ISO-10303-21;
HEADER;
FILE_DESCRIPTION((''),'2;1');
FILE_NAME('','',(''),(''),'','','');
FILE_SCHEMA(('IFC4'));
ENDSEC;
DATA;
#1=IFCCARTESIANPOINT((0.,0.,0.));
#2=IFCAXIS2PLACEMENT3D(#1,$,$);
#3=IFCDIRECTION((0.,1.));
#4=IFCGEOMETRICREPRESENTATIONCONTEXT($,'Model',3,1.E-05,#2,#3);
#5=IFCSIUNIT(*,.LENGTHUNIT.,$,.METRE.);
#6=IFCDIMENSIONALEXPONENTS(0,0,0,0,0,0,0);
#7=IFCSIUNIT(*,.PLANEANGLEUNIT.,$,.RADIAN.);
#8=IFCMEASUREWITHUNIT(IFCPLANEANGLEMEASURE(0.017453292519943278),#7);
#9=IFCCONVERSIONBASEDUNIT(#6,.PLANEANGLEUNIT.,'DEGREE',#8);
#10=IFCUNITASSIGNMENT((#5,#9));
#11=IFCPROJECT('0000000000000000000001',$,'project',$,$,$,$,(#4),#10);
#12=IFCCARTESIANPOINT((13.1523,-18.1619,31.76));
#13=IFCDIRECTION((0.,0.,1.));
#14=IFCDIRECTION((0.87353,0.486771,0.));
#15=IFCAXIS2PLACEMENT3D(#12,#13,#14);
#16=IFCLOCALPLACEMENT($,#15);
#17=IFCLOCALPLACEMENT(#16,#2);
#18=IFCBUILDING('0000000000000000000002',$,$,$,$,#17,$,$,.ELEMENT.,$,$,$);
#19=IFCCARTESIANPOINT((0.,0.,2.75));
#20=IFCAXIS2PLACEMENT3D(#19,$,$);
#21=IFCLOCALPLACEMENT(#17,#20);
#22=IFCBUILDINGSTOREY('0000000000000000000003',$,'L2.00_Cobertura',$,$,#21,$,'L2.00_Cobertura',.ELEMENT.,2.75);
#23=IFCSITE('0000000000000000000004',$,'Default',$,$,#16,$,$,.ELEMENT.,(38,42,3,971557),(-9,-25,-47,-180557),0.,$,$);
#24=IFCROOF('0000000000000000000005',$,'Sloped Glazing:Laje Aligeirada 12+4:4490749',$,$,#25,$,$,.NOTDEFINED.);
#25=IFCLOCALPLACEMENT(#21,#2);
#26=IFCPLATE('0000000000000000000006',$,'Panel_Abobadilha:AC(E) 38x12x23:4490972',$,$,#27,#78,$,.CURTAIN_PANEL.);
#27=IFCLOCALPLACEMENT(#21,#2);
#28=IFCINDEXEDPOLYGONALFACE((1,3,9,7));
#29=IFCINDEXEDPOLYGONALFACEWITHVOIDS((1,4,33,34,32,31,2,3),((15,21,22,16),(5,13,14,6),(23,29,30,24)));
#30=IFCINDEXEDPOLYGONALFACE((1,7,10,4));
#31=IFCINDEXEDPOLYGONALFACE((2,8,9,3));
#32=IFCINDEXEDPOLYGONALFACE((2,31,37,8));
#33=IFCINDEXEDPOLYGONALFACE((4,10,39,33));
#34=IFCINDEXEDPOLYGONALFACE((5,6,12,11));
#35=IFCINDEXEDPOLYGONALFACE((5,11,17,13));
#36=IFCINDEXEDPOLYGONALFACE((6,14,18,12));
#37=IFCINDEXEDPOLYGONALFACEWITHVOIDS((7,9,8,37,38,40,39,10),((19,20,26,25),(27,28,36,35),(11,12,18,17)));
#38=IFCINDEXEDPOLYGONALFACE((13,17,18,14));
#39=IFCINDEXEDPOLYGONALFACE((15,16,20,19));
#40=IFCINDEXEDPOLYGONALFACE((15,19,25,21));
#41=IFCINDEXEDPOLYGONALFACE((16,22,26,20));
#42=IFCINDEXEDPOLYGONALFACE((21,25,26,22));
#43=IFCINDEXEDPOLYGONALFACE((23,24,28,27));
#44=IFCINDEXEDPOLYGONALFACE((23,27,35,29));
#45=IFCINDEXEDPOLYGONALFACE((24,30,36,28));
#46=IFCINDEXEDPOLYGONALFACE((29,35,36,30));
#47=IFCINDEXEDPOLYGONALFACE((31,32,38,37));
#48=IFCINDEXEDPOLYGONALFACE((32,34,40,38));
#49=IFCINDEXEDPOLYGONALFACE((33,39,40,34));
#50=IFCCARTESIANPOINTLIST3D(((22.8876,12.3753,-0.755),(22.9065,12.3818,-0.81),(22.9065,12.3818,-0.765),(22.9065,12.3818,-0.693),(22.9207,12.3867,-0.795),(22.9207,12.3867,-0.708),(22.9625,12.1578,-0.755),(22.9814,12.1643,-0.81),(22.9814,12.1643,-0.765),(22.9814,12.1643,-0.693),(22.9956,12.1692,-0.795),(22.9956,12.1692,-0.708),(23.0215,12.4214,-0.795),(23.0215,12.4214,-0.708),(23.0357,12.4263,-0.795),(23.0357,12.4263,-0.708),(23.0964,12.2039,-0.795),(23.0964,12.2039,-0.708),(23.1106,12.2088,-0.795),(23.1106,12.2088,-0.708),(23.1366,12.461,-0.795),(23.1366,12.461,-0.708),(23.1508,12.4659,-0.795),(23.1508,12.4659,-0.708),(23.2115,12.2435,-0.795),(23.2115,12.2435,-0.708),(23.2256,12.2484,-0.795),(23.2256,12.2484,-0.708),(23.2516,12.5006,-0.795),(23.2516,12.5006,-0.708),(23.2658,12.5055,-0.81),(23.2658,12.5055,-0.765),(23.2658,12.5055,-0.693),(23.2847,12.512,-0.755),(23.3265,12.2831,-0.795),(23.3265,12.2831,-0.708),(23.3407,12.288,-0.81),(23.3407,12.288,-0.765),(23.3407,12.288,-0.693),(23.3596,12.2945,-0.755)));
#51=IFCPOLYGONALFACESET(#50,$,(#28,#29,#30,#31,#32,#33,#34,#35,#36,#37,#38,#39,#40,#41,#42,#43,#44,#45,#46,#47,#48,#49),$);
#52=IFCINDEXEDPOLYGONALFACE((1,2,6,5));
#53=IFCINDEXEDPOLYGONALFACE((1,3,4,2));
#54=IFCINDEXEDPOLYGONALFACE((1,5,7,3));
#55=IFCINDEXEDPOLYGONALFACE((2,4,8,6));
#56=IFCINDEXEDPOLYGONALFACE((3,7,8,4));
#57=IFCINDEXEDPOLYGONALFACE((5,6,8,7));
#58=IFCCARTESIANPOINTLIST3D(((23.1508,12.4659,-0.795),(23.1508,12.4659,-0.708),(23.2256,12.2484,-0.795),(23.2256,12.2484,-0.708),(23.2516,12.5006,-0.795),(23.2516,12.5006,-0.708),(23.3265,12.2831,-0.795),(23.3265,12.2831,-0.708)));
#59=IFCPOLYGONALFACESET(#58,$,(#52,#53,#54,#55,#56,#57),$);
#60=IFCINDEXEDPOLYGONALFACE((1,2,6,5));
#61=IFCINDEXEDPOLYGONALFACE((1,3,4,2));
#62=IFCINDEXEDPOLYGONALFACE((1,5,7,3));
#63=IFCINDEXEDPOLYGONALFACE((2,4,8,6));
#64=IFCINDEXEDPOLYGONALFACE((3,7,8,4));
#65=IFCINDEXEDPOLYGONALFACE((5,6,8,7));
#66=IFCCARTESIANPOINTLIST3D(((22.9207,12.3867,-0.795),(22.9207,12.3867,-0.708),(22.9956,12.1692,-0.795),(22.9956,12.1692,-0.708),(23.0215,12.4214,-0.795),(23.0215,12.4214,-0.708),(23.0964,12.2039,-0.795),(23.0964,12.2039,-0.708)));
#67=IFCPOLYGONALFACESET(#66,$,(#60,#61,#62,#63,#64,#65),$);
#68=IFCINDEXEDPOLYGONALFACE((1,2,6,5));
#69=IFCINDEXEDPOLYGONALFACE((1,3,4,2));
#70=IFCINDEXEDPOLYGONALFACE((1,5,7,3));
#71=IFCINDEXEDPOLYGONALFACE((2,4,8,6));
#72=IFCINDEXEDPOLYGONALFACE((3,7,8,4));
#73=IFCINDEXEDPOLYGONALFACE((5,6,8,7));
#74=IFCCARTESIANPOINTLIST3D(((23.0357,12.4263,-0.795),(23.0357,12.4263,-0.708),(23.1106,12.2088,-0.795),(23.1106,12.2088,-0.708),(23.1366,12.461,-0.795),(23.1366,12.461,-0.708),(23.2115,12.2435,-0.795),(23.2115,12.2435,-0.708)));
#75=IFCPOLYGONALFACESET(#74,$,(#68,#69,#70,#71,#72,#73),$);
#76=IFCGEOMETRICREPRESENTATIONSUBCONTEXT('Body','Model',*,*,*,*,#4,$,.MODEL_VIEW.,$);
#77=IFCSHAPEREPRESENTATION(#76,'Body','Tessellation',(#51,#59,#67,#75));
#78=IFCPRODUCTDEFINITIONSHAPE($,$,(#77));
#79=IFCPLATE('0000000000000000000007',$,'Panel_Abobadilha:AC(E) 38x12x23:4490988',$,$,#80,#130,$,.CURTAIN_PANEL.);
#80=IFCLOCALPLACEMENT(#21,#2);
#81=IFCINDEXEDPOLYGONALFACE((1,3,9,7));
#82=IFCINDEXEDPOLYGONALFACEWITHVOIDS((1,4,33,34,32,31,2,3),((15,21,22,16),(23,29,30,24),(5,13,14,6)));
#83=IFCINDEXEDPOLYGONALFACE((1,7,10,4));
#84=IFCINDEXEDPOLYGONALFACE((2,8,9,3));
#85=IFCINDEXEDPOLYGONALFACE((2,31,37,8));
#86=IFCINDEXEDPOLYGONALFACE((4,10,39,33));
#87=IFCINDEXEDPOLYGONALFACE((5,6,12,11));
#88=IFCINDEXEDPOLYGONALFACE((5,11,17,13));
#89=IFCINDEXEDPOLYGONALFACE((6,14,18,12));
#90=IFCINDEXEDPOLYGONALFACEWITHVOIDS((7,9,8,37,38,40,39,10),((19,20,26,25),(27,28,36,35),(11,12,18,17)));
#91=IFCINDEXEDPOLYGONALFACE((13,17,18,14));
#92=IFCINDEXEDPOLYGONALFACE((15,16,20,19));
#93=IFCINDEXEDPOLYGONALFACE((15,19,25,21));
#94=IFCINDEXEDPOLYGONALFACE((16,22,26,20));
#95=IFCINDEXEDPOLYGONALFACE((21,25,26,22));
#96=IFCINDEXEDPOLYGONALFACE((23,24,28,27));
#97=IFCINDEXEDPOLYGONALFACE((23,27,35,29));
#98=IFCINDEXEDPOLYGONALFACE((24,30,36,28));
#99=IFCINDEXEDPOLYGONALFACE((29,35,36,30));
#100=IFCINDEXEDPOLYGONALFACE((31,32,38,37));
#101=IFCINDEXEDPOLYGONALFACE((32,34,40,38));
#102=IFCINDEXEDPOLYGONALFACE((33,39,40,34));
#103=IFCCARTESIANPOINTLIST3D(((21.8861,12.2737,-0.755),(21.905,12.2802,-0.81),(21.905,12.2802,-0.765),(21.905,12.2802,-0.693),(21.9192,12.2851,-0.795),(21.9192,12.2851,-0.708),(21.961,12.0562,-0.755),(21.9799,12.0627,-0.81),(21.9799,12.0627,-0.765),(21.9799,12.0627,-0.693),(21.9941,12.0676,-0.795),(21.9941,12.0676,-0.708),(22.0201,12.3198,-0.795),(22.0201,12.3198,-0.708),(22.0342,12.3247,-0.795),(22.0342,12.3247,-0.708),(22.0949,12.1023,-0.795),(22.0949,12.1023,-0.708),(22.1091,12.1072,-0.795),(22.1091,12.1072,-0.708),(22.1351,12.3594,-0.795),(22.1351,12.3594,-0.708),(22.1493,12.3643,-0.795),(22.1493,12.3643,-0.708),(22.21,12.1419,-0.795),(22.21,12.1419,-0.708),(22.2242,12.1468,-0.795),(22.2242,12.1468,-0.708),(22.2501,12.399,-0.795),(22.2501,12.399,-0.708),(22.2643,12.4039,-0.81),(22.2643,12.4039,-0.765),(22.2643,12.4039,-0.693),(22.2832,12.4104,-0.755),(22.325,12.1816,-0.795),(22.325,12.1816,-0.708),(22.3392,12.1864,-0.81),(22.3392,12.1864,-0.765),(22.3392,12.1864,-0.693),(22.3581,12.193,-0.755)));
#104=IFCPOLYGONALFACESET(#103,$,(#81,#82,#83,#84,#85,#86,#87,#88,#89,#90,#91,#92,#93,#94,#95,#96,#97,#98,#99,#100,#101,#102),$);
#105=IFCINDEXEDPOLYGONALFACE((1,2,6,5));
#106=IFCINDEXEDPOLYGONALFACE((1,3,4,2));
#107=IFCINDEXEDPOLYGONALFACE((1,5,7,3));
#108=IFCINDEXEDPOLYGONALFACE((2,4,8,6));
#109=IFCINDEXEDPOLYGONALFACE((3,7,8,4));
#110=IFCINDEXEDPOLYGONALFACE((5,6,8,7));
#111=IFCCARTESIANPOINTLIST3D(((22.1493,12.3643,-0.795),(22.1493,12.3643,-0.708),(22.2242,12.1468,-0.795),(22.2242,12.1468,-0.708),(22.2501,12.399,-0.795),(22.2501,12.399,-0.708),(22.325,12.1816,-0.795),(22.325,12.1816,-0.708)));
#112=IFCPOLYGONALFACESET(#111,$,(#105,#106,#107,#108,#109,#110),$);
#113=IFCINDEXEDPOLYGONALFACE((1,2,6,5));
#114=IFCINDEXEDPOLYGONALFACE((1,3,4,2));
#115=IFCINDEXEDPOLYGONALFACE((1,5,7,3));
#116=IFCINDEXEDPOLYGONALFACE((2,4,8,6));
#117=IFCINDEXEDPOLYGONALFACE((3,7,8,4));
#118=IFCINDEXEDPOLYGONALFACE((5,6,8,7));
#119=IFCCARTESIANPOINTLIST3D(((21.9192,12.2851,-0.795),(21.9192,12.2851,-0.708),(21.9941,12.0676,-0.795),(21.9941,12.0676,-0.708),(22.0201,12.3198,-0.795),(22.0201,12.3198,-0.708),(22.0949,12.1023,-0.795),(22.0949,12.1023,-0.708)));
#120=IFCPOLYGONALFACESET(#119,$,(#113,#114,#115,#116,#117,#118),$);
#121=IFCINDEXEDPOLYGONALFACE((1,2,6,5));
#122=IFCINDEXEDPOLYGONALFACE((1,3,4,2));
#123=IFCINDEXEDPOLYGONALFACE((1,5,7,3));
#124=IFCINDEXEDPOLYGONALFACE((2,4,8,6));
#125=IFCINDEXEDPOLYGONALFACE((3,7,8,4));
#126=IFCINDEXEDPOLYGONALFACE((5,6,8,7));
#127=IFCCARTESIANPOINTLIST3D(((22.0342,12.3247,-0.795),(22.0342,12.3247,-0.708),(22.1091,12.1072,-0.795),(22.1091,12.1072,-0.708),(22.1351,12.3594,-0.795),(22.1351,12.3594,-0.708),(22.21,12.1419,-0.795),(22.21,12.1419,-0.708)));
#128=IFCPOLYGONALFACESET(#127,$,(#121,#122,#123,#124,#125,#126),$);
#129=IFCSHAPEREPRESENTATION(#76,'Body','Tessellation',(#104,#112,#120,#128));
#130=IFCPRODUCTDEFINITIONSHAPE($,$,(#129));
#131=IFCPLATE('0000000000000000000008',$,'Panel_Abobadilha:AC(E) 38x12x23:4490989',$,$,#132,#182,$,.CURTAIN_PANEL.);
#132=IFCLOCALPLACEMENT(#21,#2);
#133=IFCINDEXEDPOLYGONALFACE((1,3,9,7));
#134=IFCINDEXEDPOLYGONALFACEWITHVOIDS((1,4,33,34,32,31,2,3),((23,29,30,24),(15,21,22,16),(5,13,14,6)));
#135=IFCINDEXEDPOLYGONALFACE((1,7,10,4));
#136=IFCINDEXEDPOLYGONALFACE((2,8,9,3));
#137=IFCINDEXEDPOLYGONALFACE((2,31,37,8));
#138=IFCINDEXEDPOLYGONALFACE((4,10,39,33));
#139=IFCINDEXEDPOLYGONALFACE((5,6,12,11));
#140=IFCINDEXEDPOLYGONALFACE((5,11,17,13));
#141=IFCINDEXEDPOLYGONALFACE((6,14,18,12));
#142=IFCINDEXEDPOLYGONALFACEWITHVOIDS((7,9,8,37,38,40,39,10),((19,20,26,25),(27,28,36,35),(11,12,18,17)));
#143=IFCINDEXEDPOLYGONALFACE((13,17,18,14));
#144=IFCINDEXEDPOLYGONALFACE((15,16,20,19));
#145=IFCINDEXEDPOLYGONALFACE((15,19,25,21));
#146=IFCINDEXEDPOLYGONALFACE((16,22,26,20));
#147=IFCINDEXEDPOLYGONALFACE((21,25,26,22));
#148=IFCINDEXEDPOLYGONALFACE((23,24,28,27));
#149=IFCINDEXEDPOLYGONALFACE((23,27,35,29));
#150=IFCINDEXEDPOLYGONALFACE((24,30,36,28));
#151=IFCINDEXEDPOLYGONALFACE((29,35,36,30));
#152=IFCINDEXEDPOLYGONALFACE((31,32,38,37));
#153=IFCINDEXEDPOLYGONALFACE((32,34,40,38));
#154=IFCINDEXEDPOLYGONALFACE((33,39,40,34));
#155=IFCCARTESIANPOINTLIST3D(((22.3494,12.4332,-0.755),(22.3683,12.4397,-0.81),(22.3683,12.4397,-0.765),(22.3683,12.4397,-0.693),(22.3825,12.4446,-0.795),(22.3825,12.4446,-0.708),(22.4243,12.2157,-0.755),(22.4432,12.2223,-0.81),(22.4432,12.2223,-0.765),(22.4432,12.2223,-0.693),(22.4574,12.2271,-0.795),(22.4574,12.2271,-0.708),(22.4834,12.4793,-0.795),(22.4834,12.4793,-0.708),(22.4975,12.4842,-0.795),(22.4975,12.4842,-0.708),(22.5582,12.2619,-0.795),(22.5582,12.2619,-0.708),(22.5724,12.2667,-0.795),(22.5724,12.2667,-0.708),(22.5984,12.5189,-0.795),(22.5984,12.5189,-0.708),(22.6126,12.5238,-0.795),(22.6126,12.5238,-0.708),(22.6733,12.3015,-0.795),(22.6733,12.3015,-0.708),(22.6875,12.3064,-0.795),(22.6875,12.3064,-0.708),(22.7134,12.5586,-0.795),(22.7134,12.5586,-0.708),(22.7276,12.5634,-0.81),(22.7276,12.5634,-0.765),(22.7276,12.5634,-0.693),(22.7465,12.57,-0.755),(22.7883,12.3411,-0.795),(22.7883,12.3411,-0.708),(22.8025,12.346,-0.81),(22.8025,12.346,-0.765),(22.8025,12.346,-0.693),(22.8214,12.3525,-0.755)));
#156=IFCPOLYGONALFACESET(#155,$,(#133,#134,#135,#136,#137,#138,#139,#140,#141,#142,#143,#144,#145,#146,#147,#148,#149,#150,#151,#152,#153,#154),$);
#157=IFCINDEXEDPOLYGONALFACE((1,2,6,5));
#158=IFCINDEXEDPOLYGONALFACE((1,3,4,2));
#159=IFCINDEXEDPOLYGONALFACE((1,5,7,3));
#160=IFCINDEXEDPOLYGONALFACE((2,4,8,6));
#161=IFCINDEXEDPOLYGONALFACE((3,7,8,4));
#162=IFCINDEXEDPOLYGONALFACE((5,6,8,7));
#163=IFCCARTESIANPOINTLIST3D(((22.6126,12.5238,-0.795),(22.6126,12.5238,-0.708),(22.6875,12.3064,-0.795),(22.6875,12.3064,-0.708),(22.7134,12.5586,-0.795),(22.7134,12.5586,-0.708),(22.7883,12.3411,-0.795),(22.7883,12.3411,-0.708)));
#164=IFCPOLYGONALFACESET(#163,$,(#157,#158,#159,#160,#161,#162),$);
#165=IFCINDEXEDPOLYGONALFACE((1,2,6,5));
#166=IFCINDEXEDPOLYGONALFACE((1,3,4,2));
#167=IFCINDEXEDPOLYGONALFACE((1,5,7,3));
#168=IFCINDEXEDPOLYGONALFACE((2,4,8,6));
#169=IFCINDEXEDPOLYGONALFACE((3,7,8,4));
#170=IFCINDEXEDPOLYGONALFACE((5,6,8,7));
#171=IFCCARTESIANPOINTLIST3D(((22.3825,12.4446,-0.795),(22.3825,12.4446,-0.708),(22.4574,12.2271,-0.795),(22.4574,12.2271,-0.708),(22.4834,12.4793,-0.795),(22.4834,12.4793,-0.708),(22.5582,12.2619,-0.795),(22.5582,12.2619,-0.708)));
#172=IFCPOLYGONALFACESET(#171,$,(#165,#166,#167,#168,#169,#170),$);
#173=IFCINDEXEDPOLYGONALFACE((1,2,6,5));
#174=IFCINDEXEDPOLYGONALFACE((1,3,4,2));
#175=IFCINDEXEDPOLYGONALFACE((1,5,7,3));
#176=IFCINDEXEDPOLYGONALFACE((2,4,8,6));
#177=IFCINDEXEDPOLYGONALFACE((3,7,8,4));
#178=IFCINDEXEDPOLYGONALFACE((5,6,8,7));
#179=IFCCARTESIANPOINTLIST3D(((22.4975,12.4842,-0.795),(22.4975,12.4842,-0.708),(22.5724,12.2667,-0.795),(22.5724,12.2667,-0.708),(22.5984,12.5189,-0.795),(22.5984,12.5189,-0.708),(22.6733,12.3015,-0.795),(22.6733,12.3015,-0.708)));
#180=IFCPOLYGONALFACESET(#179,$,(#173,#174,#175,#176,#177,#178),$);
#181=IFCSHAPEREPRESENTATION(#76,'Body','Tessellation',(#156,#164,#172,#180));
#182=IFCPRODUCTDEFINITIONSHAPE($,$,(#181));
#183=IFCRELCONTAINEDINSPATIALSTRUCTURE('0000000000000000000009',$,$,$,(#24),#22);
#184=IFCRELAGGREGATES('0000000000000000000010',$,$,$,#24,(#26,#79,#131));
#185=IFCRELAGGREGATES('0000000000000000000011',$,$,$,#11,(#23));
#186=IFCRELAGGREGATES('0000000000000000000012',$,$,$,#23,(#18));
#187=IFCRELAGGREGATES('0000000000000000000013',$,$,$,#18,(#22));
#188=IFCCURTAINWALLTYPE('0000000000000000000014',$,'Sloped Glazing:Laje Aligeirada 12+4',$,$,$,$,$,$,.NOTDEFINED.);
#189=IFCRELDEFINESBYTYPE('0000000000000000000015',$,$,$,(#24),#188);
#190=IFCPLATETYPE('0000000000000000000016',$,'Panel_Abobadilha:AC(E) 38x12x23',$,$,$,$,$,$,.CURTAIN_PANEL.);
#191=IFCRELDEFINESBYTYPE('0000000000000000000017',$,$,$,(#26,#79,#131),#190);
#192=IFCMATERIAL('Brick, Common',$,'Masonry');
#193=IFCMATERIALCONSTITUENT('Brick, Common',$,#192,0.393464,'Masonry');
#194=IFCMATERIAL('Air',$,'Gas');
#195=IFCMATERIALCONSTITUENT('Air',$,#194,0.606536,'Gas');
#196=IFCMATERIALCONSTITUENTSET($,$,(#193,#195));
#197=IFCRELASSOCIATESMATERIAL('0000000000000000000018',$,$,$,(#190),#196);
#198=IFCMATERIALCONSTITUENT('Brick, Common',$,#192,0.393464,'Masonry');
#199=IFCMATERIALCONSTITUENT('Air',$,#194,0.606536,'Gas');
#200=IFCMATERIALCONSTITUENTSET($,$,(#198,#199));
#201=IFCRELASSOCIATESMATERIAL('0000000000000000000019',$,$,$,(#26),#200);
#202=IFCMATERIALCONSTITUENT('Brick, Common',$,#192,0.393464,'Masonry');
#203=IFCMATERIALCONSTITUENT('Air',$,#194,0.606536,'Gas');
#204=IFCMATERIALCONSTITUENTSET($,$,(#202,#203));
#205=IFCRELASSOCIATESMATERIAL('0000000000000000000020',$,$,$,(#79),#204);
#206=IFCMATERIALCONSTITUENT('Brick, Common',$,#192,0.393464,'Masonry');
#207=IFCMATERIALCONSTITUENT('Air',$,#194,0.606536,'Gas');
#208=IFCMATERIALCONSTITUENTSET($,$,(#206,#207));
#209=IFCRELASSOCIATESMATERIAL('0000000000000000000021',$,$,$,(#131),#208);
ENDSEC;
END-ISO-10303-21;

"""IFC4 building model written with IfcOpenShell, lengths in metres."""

from ifc_helpers import new_model, entity, si_unit, converted_unit, direction, frame, origin, place, context, subcontext, project, spatial, indexed_curve, outline, extrude, source, transform, mapped, material, constituent, constituent_set, type_object, type_shapes, element, aggregate, save


model = new_model("IFC4")

# Units and contexts
model_context = context("Model", 3, precision=1e-05, world=origin(), true_north=direction((0.0, 1.0)))
body_context = subcontext(model_context, "Body", "Model", "MODEL_VIEW")
ifc_project = project(units=[si_unit("LENGTHUNIT", "METRE"), converted_unit("PLANEANGLEUNIT", "DEGREE", entity("IfcPlaneAngleMeasure", 0.017453292519943278), si_unit("PLANEANGLEUNIT", "RADIAN"), dimensions=[0, 0, 0, 0, 0, 0, 0])], contexts=[model_context])

# Site, building, storey
site_placement = place(None, frame((13.1523, -18.1619, 31.76), z_axis=(0.0, 0.0, 1.0), x_axis=(0.87353, 0.486771, 0.0)))
site = spatial("IfcSite", under=ifc_project, at=site_placement, Name="Default", CompositionType="ELEMENT", RefLatitude=(38, 42, 3, 971557), RefLongitude=(-9, -25, -47, -180557), RefElevation=0.0)
building_placement = place(site_placement, origin())
building = spatial("IfcBuilding", under=site, at=building_placement, CompositionType="ELEMENT")
storey_placement = place(building_placement, frame((0.0, 0.0, 2.75)))
storey = spatial("IfcBuildingStorey", under=building, at=storey_placement, Name="L2.00_Cobertura", LongName="L2.00_Cobertura", CompositionType="ELEMENT", Elevation=2.75)

# Roof, plates
curtain_wall_type = type_object("IfcCurtainWallType", Name="Sloped Glazing:Laje Aligeirada 12+4", PredefinedType="NOTDEFINED")
roof_placement = place(storey_placement, frame((0.0, 0.0, -2.75)))
roof = element("IfcRoof", 1, at=roof_placement, inside=storey, type_object=curtain_wall_type, Name="Sloped Glazing:Laje Aligeirada 12+4:4490749", PredefinedType="NOTDEFINED")
ifc_material_1 = material(Name="Brick, Common", Category="Masonry")
ifc_material_2 = material(Name="Air", Category="Gas")
ifc_constituent_1 = constituent(ifc_material_1, Name="Brick, Common", Category="Masonry", fraction=0.393464)
ifc_constituent_2 = constituent(ifc_material_2, Name="Air", Category="Gas", fraction=0.606536)
ifc_constituent_set_1 = constituent_set(constituents=[ifc_constituent_1, ifc_constituent_2])
plate_type = type_object("IfcPlateType", Name="Panel_Abobadilha:AC(E) 38x12x23", PredefinedType="CURTAIN_PANEL", material=ifc_constituent_set_1)
shared_shape_1 = source(origin(), body_context, "Body", "SweptSolid", [
    extrude(outline(indexed_curve([(-0.19, -0.0543), (0.19, -0.0543), (0.19, -0.0093), (0.21, 0.0007), (0.19, 0.0628), (-0.19, 0.0628), (-0.21, 0.0007), (-0.19, -0.0093), (-0.19, -0.0543)], self_intersect=False), holes=[indexed_curve([(-0.0683, 0.0477), (-0.0683, -0.0393), (-0.175, -0.0393), (-0.175, 0.0477), (-0.0683, 0.0477)], self_intersect=False), indexed_curve([(0.0533, 0.0477), (0.0533, -0.0393), (-0.0533, -0.0393), (-0.0533, 0.0477), (0.0533, 0.0477)], self_intersect=False), indexed_curve([(0.175, 0.0477), (0.175, -0.0393), (0.0683, -0.0393), (0.0683, 0.0477), (0.175, 0.0477)], self_intersect=False)]), frame((0.0, 0.0543, 0.0)), (0.0, 0.0, 1.0), 0.23),
    extrude(outline(indexed_curve([(-0.0533, -0.0435), (0.0533, -0.0435), (0.0533, 0.0435), (-0.0533, 0.0435), (-0.0533, -0.0435)], self_intersect=False)), frame((0.1217, 0.0585, 0.0), z_axis=(0.0, 0.0, 1.0), x_axis=(-1.0, 0.0, 0.0)), (0.0, 0.0, 1.0), 0.23),
    extrude(outline(indexed_curve([(-0.0533, -0.0435), (0.0533, -0.0435), (0.0533, 0.0435), (-0.0533, 0.0435), (-0.0533, -0.0435)], self_intersect=False)), frame((-0.1217, 0.0585, 0.0), z_axis=(0.0, 0.0, 1.0), x_axis=(-1.0, 0.0, 0.0)), (0.0, 0.0, 1.0), 0.23),
    extrude(outline(indexed_curve([(-0.0533, -0.0435), (0.0533, -0.0435), (0.0533, 0.0435), (-0.0533, 0.0435), (-0.0533, -0.0435)], self_intersect=False)), frame((0.0, 0.0585, 0.0), z_axis=(0.0, 0.0, 1.0), x_axis=(-1.0, 0.0, 0.0)), (0.0, 0.0, 1.0), 0.23),
])
type_shapes(plate_type, [shared_shape_1])
ifc_constituent_3 = constituent(ifc_material_1, Name="Brick, Common", Category="Masonry", fraction=0.393464)
ifc_constituent_4 = constituent(ifc_material_2, Name="Air", Category="Gas", fraction=0.606536)
ifc_constituent_set_2 = constituent_set(constituents=[ifc_constituent_3, ifc_constituent_4])
plate_1_placement = place(roof_placement, frame((23.0862, 12.4436, 1.94), z_axis=(0.325568, -0.945519, 0.0), x_axis=(0.945519, 0.325568, 0.0)))
plate_1 = element("IfcPlate", 2, at=plate_1_placement, type_object=plate_type, material=ifc_constituent_set_2, Name="Panel_Abobadilha:AC(E) 38x12x23:4490972", PredefinedType="CURTAIN_PANEL", context=body_context, shape_type="MappedRepresentation", body=[
    mapped(shared_shape_1, transform((0.0, 0.0, 0.0), scale=1.0)),
])
ifc_constituent_5 = constituent(ifc_material_1, Name="Brick, Common", Category="Masonry", fraction=0.393464)
ifc_constituent_6 = constituent(ifc_material_2, Name="Air", Category="Gas", fraction=0.606536)
ifc_constituent_set_3 = constituent_set(constituents=[ifc_constituent_5, ifc_constituent_6])
plate_2_placement = place(roof_placement, frame((22.0847, 12.3421, 1.94), z_axis=(0.325568, -0.945519, 0.0), x_axis=(0.945519, 0.325568, 0.0)))
plate_2 = element("IfcPlate", 3, at=plate_2_placement, type_object=plate_type, material=ifc_constituent_set_3, Name="Panel_Abobadilha:AC(E) 38x12x23:4490988", PredefinedType="CURTAIN_PANEL", context=body_context, shape_type="MappedRepresentation", body=[
    mapped(shared_shape_1, transform((0.0, 0.0, 0.0), scale=1.0)),
])
ifc_constituent_7 = constituent(ifc_material_1, Name="Brick, Common", Category="Masonry", fraction=0.393464)
ifc_constituent_8 = constituent(ifc_material_2, Name="Air", Category="Gas", fraction=0.606536)
ifc_constituent_set_4 = constituent_set(constituents=[ifc_constituent_7, ifc_constituent_8])
plate_3_placement = place(roof_placement, frame((22.548, 12.5016, 1.94), z_axis=(0.325568, -0.945519, 0.0), x_axis=(0.945519, 0.325568, 0.0)))
plate_3 = element("IfcPlate", 4, at=plate_3_placement, type_object=plate_type, material=ifc_constituent_set_4, Name="Panel_Abobadilha:AC(E) 38x12x23:4490989", PredefinedType="CURTAIN_PANEL", context=body_context, shape_type="MappedRepresentation", body=[
    mapped(shared_shape_1, transform((0.0, 0.0, 0.0), scale=1.0)),
])
aggregate(roof, [plate_1, plate_2, plate_3])

save(model, "model.ifc")
